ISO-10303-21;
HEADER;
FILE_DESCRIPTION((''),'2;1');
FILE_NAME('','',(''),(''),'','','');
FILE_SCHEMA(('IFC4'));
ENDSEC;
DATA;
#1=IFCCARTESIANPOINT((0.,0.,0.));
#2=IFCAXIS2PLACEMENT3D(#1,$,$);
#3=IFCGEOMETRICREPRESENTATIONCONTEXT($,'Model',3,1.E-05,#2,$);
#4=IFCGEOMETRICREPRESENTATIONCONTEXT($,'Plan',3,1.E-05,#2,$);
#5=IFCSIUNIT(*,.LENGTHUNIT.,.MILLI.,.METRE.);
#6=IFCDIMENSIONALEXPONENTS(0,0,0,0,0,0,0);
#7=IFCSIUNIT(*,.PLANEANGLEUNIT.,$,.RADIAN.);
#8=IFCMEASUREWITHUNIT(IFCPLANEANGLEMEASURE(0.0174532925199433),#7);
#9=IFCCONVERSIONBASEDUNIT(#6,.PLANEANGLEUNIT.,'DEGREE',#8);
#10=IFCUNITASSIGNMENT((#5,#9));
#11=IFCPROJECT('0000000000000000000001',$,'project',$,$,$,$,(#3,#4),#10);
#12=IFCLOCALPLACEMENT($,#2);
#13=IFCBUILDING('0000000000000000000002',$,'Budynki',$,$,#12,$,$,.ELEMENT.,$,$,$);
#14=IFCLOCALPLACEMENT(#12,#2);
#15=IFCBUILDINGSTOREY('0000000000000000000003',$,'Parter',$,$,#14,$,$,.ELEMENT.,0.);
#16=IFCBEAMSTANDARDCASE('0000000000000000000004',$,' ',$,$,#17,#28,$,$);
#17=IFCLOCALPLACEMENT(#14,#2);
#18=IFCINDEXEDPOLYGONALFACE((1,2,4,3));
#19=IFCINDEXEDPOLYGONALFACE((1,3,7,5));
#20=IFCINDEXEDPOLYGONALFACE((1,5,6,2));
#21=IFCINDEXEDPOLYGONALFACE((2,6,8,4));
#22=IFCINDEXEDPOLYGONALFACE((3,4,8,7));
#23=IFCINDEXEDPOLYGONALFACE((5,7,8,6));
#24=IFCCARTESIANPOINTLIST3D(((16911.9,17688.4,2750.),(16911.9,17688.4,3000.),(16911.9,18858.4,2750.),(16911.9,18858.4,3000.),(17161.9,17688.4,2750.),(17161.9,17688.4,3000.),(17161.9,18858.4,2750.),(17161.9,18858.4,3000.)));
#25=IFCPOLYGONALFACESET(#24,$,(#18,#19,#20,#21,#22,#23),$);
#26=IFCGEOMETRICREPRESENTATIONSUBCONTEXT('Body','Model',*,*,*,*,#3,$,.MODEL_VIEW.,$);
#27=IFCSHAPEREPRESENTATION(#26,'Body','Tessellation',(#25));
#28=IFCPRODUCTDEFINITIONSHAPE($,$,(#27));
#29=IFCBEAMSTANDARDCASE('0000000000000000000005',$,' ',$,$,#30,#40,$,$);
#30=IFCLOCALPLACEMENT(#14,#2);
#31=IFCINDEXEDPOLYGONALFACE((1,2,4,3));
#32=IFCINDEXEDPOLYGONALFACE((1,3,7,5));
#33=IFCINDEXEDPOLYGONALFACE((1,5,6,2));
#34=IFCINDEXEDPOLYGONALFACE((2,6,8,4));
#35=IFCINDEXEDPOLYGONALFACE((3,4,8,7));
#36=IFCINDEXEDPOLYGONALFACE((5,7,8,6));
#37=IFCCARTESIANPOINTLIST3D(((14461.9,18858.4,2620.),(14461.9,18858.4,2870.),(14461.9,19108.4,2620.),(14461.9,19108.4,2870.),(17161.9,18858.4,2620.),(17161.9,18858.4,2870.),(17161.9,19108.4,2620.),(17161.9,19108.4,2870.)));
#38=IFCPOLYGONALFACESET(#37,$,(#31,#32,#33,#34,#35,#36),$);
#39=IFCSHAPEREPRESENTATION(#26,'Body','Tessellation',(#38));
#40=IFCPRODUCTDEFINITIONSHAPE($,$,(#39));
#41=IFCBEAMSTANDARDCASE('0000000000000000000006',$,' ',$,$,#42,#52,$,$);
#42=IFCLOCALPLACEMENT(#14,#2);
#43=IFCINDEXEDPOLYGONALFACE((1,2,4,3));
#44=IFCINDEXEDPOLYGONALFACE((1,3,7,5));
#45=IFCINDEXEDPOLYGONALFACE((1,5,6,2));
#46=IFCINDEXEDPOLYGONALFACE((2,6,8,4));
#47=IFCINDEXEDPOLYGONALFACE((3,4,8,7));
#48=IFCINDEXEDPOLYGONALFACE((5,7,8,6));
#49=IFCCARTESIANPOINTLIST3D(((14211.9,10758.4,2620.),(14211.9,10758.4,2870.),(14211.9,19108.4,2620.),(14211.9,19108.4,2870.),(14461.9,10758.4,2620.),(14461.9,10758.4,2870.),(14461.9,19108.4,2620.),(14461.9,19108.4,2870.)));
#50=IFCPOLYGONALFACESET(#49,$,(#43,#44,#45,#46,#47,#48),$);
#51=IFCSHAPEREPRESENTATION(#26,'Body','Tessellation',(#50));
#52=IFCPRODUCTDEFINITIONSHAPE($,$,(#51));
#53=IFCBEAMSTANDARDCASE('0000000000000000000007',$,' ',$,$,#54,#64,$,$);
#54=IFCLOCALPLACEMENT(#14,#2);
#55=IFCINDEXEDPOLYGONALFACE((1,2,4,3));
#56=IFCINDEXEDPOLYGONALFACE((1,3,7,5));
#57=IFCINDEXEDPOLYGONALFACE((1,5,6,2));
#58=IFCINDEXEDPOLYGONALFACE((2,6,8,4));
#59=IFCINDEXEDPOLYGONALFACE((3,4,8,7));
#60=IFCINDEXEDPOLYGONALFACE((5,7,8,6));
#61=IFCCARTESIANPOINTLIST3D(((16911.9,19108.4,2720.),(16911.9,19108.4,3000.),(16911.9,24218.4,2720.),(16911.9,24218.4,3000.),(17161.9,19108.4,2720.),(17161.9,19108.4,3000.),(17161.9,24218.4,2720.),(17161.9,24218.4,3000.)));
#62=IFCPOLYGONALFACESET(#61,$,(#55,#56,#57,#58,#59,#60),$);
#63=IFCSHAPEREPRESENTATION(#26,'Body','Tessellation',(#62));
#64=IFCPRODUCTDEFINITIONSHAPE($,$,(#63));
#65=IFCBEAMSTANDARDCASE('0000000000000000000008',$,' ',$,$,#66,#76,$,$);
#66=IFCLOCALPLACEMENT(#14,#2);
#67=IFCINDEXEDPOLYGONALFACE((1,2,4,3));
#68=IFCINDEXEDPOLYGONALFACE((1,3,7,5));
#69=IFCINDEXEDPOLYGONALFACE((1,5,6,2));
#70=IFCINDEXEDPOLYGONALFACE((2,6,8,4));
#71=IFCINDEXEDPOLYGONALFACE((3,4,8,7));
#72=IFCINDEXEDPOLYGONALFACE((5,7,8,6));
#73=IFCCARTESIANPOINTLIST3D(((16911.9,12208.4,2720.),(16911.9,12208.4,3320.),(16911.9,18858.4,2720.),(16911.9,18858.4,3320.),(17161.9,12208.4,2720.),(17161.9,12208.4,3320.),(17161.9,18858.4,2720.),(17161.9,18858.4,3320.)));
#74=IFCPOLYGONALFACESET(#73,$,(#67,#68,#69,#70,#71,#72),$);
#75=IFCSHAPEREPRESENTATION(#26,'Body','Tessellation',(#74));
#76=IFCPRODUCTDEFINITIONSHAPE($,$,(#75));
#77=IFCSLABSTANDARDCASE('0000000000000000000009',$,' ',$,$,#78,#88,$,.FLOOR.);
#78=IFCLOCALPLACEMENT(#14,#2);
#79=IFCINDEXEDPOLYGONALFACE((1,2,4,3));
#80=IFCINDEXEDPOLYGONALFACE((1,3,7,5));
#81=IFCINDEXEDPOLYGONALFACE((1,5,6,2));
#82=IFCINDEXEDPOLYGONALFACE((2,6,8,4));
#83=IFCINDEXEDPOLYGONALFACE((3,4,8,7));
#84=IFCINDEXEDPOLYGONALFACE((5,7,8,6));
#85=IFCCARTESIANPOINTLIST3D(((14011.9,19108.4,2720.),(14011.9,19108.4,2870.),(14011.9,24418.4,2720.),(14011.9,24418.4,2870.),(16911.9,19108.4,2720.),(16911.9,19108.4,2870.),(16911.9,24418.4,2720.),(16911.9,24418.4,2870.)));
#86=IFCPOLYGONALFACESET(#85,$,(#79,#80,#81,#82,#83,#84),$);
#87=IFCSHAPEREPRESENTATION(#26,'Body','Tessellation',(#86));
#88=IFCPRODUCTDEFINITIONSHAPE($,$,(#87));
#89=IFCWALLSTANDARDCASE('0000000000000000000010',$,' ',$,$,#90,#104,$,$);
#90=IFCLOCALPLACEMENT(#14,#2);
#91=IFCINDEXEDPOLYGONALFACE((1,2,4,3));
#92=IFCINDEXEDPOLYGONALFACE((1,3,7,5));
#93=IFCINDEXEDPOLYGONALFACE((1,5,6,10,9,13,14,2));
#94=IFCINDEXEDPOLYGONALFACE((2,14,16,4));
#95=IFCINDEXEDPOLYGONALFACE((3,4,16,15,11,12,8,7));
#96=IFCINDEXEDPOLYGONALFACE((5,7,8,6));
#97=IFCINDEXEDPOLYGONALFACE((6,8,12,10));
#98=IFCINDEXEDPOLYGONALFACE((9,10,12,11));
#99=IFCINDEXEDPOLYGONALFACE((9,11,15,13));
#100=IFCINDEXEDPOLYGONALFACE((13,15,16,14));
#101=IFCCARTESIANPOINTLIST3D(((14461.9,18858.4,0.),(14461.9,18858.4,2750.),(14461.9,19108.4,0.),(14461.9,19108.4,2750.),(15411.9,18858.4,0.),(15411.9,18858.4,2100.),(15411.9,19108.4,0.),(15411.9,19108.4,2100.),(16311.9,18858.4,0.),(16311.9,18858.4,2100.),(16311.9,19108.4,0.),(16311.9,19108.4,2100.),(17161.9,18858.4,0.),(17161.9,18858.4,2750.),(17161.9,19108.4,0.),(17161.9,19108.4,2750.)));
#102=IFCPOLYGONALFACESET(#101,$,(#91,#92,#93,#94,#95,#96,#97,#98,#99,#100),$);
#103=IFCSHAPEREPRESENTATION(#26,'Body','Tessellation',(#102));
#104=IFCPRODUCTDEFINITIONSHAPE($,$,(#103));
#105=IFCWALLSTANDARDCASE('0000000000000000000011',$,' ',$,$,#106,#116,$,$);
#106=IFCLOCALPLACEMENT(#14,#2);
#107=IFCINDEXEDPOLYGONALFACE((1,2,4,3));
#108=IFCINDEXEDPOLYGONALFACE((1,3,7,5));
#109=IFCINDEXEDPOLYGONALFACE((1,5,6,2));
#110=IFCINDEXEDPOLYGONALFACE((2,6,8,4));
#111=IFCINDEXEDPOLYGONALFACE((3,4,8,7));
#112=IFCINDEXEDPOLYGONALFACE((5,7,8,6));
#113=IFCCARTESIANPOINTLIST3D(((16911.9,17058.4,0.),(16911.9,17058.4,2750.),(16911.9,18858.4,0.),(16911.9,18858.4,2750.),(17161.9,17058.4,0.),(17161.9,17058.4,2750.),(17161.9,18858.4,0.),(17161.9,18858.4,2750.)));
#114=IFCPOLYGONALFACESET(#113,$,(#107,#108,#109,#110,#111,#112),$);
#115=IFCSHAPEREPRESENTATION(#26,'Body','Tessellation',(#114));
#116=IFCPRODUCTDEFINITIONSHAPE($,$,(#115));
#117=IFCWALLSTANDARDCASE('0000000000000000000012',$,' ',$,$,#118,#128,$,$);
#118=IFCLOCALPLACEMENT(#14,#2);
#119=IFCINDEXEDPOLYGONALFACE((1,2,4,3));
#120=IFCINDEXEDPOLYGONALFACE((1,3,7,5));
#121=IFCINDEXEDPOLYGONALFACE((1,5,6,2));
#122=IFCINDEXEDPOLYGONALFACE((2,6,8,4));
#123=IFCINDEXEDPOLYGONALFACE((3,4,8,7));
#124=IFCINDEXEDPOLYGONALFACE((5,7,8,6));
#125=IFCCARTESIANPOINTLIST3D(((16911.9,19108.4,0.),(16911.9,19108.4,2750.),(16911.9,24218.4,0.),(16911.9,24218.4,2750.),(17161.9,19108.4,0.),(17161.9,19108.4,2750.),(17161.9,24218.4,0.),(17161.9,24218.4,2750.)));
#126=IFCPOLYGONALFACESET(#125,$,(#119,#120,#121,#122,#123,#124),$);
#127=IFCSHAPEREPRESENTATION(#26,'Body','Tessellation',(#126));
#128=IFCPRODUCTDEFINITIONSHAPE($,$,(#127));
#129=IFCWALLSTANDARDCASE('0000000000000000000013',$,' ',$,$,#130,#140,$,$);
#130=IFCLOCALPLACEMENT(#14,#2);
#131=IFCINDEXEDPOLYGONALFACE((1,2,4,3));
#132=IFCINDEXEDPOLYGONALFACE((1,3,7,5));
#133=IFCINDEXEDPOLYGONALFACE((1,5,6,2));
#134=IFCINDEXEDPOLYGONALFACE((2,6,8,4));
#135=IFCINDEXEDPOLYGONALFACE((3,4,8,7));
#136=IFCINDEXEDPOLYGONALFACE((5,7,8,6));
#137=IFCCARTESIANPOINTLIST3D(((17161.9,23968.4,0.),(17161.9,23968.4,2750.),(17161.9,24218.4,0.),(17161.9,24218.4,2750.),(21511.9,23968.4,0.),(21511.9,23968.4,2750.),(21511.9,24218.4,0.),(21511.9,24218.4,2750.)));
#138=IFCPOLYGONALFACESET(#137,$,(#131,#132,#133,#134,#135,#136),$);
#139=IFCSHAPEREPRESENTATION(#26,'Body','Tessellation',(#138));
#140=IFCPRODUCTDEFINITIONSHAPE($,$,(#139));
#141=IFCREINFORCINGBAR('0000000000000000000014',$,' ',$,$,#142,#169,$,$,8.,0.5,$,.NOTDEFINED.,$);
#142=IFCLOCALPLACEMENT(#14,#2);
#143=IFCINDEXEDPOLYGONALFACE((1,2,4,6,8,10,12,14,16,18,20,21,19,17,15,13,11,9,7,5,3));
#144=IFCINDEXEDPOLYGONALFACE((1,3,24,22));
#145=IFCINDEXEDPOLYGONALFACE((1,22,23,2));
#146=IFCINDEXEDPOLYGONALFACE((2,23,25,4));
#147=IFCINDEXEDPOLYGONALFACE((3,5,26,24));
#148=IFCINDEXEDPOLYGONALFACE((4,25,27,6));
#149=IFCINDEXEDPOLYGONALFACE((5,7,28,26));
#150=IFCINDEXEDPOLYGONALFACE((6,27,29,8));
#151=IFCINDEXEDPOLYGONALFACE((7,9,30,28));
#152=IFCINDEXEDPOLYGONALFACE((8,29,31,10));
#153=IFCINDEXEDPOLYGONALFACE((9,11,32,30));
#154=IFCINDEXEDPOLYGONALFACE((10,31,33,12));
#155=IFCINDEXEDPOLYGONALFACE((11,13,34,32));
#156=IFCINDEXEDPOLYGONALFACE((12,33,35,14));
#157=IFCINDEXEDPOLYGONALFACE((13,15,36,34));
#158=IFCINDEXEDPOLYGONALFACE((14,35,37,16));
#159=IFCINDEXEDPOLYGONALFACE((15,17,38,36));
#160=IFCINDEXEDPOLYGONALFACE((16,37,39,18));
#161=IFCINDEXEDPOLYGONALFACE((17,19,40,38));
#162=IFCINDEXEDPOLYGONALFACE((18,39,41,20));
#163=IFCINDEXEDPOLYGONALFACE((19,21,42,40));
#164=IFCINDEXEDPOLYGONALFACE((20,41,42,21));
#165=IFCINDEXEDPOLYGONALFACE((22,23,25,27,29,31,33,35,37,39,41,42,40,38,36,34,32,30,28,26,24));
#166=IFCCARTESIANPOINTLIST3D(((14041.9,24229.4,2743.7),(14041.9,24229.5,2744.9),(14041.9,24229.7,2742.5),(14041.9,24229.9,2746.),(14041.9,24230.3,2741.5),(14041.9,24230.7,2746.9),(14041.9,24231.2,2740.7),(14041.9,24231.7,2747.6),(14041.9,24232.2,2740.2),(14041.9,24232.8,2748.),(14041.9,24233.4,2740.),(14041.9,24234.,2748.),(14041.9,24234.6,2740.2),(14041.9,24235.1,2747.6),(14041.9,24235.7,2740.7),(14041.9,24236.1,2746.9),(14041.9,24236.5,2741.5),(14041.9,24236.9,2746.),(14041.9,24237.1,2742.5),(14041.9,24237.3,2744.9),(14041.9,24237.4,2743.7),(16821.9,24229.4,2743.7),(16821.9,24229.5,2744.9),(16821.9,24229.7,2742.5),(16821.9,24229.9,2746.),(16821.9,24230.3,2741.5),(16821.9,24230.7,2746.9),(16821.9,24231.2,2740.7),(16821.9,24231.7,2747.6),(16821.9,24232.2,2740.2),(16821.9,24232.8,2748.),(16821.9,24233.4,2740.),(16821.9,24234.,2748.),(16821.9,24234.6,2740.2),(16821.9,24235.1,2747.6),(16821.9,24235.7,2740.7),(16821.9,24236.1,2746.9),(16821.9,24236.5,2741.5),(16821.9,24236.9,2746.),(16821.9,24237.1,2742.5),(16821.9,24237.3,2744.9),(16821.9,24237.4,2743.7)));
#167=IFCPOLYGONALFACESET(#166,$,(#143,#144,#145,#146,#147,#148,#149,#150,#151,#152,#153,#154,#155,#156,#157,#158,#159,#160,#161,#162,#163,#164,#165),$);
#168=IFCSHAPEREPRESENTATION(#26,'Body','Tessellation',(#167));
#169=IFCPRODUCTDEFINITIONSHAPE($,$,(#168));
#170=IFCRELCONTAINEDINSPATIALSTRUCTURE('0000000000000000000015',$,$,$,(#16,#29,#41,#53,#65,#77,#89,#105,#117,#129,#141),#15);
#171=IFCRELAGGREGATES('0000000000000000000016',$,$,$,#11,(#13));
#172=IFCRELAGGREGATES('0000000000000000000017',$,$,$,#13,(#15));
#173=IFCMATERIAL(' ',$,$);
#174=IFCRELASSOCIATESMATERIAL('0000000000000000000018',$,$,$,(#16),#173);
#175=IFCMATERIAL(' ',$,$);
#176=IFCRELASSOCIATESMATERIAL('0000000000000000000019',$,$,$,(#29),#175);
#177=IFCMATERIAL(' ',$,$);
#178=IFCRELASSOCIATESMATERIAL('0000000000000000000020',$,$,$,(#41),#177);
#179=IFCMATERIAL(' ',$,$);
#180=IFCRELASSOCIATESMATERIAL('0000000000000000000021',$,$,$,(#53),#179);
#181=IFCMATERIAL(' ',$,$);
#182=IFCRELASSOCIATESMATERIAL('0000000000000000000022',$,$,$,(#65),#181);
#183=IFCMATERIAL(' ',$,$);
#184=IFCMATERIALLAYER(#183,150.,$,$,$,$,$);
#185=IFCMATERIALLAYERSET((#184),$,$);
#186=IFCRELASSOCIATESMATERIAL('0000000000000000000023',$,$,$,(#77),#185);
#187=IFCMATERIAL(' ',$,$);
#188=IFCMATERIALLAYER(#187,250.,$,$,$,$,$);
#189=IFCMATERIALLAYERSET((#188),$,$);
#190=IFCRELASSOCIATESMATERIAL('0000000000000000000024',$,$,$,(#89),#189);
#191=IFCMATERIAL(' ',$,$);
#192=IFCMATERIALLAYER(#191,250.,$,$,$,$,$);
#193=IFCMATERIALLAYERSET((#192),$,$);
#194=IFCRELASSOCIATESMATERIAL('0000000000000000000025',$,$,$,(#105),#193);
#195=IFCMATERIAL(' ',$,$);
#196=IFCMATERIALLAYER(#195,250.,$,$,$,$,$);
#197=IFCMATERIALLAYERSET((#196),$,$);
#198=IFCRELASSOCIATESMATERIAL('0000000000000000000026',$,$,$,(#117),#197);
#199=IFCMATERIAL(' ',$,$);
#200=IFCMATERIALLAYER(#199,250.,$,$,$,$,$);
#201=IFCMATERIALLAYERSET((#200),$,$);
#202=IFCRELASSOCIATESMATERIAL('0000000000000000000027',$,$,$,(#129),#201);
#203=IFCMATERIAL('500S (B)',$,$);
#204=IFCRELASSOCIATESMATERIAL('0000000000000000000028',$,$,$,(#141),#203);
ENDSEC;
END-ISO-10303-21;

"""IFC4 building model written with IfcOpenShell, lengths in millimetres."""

from ifc_helpers import new_model, entity, si_unit, converted_unit, frame, frame_2d, origin, origin_with_axes, place, context, subcontext, project, spatial, polyline, rectangle, outline, extrude, material, layer, layer_set, layer_usage, material_profile, profile_set, profile_usage, element, save


model = new_model("IFC4")

# Units and contexts
model_context = context("Model", 3, precision=1e-05, world=origin())
plan_context = context("Plan", 3, precision=1e-05, world=origin())
body_context = subcontext(model_context, "Body", "Model", "MODEL_VIEW")
ifc_project = project(units=[si_unit("LENGTHUNIT", "METRE", prefix="MILLI"), converted_unit("PLANEANGLEUNIT", "DEGREE", entity("IfcPlaneAngleMeasure", 0.0174532925199433), si_unit("PLANEANGLEUNIT", "RADIAN"), dimensions=[0, 0, 0, 0, 0, 0, 0])], contexts=[model_context, plan_context])

# Building, storey
building_placement = place(None, origin())
building = spatial("IfcBuilding", under=ifc_project, at=building_placement, Name="Budynki", CompositionType="ELEMENT")
storey_placement = place(building_placement, origin())
storey = spatial("IfcBuildingStorey", under=building, at=storey_placement, Name="Parter", CompositionType="ELEMENT", Elevation=0.0)

# Beams
ifc_material_1 = material(Name=" ")
ifc_material_profile_1 = material_profile(ifc_material_1, rectangle(XDim=250.0, YDim=250.0, at=frame_2d((125.0, -125.0), x_axis=(0.0, 1.0))))
ifc_profile_set_1 = profile_set([ifc_material_profile_1])
ifc_profile_usage_1 = profile_usage(ifc_profile_set_1)
beam_1_placement = place(storey_placement, frame((16911.9, 18858.4, 2750.0), z_axis=(0.0, 0.0, 1.0), x_axis=(0.0, -1.0, 0.0)))
element("IfcBeamStandardCase", 1, at=beam_1_placement, inside=storey, material=ifc_profile_usage_1, Name=" ", context=body_context, shape_type="SweptSolid", body=[
    extrude(rectangle(XDim=250.0, YDim=250.0, at=frame_2d((125.0, -125.0), x_axis=(0.0, 1.0))), frame((0.0, 0.0, 0.0), z_axis=(1.0, 0.0, 0.0), x_axis=(0.0, 0.0, 1.0)), (0.0, 0.0, 1.0), 1170.0),
])
ifc_material_2 = material(Name=" ")
ifc_material_profile_2 = material_profile(ifc_material_2, rectangle(XDim=250.0, YDim=250.0, at=frame_2d((125.0, -125.0), x_axis=(0.0, 1.0))))
ifc_profile_set_2 = profile_set([ifc_material_profile_2])
ifc_profile_usage_2 = profile_usage(ifc_profile_set_2)
beam_2_placement = place(storey_placement, frame((17161.9, 19108.4, 2620.0), z_axis=(0.0, 0.0, 1.0), x_axis=(-1.0, 0.0, 0.0)))
element("IfcBeamStandardCase", 2, at=beam_2_placement, inside=storey, material=ifc_profile_usage_2, Name=" ", context=body_context, shape_type="SweptSolid", body=[
    extrude(rectangle(XDim=250.0, YDim=250.0, at=frame_2d((125.0, -125.0), x_axis=(0.0, 1.0))), frame((0.0, 0.0, 0.0), z_axis=(1.0, 0.0, 0.0), x_axis=(0.0, 0.0, 1.0)), (0.0, 0.0, 1.0), 2700.0),
])
ifc_material_3 = material(Name=" ")
ifc_material_profile_3 = material_profile(ifc_material_3, rectangle(XDim=250.0, YDim=250.0, at=frame_2d((125.0, -125.0), x_axis=(0.0, 1.0))))
ifc_profile_set_3 = profile_set([ifc_material_profile_3])
ifc_profile_usage_3 = profile_usage(ifc_profile_set_3)
beam_3_placement = place(storey_placement, frame((14211.9, 19108.4, 2620.0), z_axis=(0.0, 0.0, 1.0), x_axis=(0.0, -1.0, 0.0)))
element("IfcBeamStandardCase", 3, at=beam_3_placement, inside=storey, material=ifc_profile_usage_3, Name=" ", context=body_context, shape_type="SweptSolid", body=[
    extrude(rectangle(XDim=250.0, YDim=250.0, at=frame_2d((125.0, -125.0), x_axis=(0.0, 1.0))), frame((0.0, 0.0, 0.0), z_axis=(1.0, 0.0, 0.0), x_axis=(0.0, 0.0, 1.0)), (0.0, 0.0, 1.0), 8350.0),
])
ifc_material_4 = material(Name=" ")
ifc_material_profile_4 = material_profile(ifc_material_4, rectangle(XDim=250.0, YDim=280.0, at=frame_2d((140.0, -125.0), x_axis=(0.0, 1.0))))
ifc_profile_set_4 = profile_set([ifc_material_profile_4])
ifc_profile_usage_4 = profile_usage(ifc_profile_set_4)
beam_4_placement = place(storey_placement, frame((16911.9, 24218.4, 2720.0), z_axis=(0.0, 0.0, 1.0), x_axis=(0.0, -1.0, 0.0)))
element("IfcBeamStandardCase", 4, at=beam_4_placement, inside=storey, material=ifc_profile_usage_4, Name=" ", context=body_context, shape_type="SweptSolid", body=[
    extrude(rectangle(XDim=250.0, YDim=280.0, at=frame_2d((140.0, -125.0), x_axis=(0.0, 1.0))), frame((0.0, 0.0, 0.0), z_axis=(1.0, 0.0, 0.0), x_axis=(0.0, 0.0, 1.0)), (0.0, 0.0, 1.0), 5110.0),
])
ifc_material_5 = material(Name=" ")
ifc_material_profile_5 = material_profile(ifc_material_5, rectangle(XDim=250.0, YDim=600.0, at=frame_2d((300.0, -125.0), x_axis=(0.0, 1.0))))
ifc_profile_set_5 = profile_set([ifc_material_profile_5])
ifc_profile_usage_5 = profile_usage(ifc_profile_set_5)
beam_5_placement = place(storey_placement, frame((16911.9, 18858.4, 2720.0), z_axis=(0.0, 0.0, 1.0), x_axis=(0.0, -1.0, 0.0)))
element("IfcBeamStandardCase", 5, at=beam_5_placement, inside=storey, material=ifc_profile_usage_5, Name=" ", context=body_context, shape_type="SweptSolid", body=[
    extrude(rectangle(XDim=250.0, YDim=600.0, at=frame_2d((300.0, -125.0), x_axis=(0.0, 1.0))), frame((0.0, 0.0, 0.0), z_axis=(1.0, 0.0, 0.0), x_axis=(0.0, 0.0, 1.0)), (0.0, 0.0, 1.0), 6650.0),
])

# Slab
ifc_material_6 = material(Name=" ")
ifc_layer_1 = layer(ifc_material_6, 150.0)
ifc_layer_set_1 = layer_set([ifc_layer_1])
ifc_layer_usage_1 = layer_usage(ifc_layer_set_1, "AXIS3", "POSITIVE", 0.0)
slab_placement = place(storey_placement, frame((14011.9, 19108.4, 2720.0)))
element("IfcSlabStandardCase", 6, at=slab_placement, inside=storey, material=ifc_layer_usage_1, Name=" ", PredefinedType="FLOOR", context=body_context, shape_type="SweptSolid", body=[
    extrude(rectangle(XDim=5310.0, YDim=2900.0, at=frame_2d((-1450.0, 2655.0), x_axis=(0.0, 1.0))), frame((2900.0, 0.0, 0.0), z_axis=(0.0, 0.0, 1.0), x_axis=(1.0, 0.0, 0.0)), (0.0, 0.0, 1.0), 150.0),
])

# Wall, opening
ifc_material_7 = material(Name=" ")
ifc_layer_2 = layer(ifc_material_7, 250.0)
ifc_layer_set_2 = layer_set([ifc_layer_2])
ifc_layer_usage_2 = layer_usage(ifc_layer_set_2, "AXIS2", "POSITIVE", 0.0)
wall_1_placement = place(storey_placement, frame((14461.9, 18858.4, 0.0)))
wall_1 = element("IfcWallStandardCase", 7, at=wall_1_placement, inside=storey, material=ifc_layer_usage_2, Name=" ", context=body_context, shape_type="SweptSolid", body=[
    extrude(rectangle(XDim=2700.0, YDim=250.0, at=frame_2d((1350.0, 125.0), x_axis=(1.0, 0.0))), origin_with_axes(), (0.0, 0.0, 1.0), 2750.0),
])
opening_placement = place(wall_1_placement, frame((950.0, 0.0, 0.0), z_axis=(0.0, 1.0, 0.0), x_axis=(0.0, 0.0, 1.0)))
element("IfcOpeningStandardCase", 8, at=opening_placement, cuts=wall_1, PredefinedType="OPENING", context=body_context, shape_type="SweptSolid", body=[
    extrude(outline(polyline([(0.0, 900.0), (2100.0, 900.0), (2100.0, 0.0), (0.0, 0.0), (0.0, 900.0)])), origin_with_axes(), (0.0, 0.0, 1.0), 250.0),
])

# Walls
ifc_material_8 = material(Name=" ")
ifc_layer_3 = layer(ifc_material_8, 250.0)
ifc_layer_set_3 = layer_set([ifc_layer_3])
ifc_layer_usage_3 = layer_usage(ifc_layer_set_3, "AXIS2", "POSITIVE", 0.0)
wall_2_placement = place(storey_placement, frame((16911.9, 18858.4, 0.0), z_axis=(0.0, 0.0, 1.0), x_axis=(0.0, -1.0, 0.0)))
element("IfcWallStandardCase", 9, at=wall_2_placement, inside=storey, material=ifc_layer_usage_3, Name=" ", context=body_context, shape_type="SweptSolid", body=[
    extrude(rectangle(XDim=1800.0, YDim=250.0, at=frame_2d((900.0, 125.0), x_axis=(1.0, 0.0))), origin_with_axes(), (0.0, 0.0, 1.0), 2750.0),
])
ifc_material_9 = material(Name=" ")
ifc_layer_4 = layer(ifc_material_9, 250.0)
ifc_layer_set_4 = layer_set([ifc_layer_4])
ifc_layer_usage_4 = layer_usage(ifc_layer_set_4, "AXIS2", "POSITIVE", 0.0)
wall_3_placement = place(storey_placement, frame((17161.9, 19108.4, 0.0), z_axis=(0.0, 0.0, 1.0), x_axis=(0.0, 1.0, 0.0)))
element("IfcWallStandardCase", 10, at=wall_3_placement, inside=storey, material=ifc_layer_usage_4, Name=" ", context=body_context, shape_type="SweptSolid", body=[
    extrude(rectangle(XDim=5110.0, YDim=250.0, at=frame_2d((2555.0, 125.0), x_axis=(1.0, 0.0))), origin_with_axes(), (0.0, 0.0, 1.0), 2750.0),
])
ifc_material_10 = material(Name=" ")
ifc_layer_5 = layer(ifc_material_10, 250.0)
ifc_layer_set_5 = layer_set([ifc_layer_5])
ifc_layer_usage_5 = layer_usage(ifc_layer_set_5, "AXIS2", "POSITIVE", 0.0)
wall_4_placement = place(storey_placement, frame((17161.9, 23968.4, 0.0)))
element("IfcWallStandardCase", 11, at=wall_4_placement, inside=storey, material=ifc_layer_usage_5, Name=" ", context=body_context, shape_type="SweptSolid", body=[
    extrude(rectangle(XDim=4350.0, YDim=250.0, at=frame_2d((2175.0, 125.0), x_axis=(1.0, 0.0))), origin_with_axes(), (0.0, 0.0, 1.0), 2750.0),
])

# Reinforcing bar
ifc_material_11 = material(Name="500S (B)")
reinforcing_bar_1_placement = place(storey_placement, frame((16821.9, 24233.4, 2744.0)))
element("IfcReinforcingBar", 12, at=reinforcing_bar_1_placement, inside=storey, material=ifc_material_11, Name=" ", CrossSectionArea=0.5, NominalDiameter=8.0, PredefinedType="NOTDEFINED", context=body_context, shape_type="AdvancedSweptSolid", body=[
    entity("IfcSweptDiskSolid", entity("IfcPolyline", [entity("IfcCartesianPoint", [0.0, 0.0, 0.0]), entity("IfcCartesianPoint", [-2780.0, 0.0, 0.0])]), 4.0, None, 0.0, 1.0),
])

save(model, "model.ifc")
